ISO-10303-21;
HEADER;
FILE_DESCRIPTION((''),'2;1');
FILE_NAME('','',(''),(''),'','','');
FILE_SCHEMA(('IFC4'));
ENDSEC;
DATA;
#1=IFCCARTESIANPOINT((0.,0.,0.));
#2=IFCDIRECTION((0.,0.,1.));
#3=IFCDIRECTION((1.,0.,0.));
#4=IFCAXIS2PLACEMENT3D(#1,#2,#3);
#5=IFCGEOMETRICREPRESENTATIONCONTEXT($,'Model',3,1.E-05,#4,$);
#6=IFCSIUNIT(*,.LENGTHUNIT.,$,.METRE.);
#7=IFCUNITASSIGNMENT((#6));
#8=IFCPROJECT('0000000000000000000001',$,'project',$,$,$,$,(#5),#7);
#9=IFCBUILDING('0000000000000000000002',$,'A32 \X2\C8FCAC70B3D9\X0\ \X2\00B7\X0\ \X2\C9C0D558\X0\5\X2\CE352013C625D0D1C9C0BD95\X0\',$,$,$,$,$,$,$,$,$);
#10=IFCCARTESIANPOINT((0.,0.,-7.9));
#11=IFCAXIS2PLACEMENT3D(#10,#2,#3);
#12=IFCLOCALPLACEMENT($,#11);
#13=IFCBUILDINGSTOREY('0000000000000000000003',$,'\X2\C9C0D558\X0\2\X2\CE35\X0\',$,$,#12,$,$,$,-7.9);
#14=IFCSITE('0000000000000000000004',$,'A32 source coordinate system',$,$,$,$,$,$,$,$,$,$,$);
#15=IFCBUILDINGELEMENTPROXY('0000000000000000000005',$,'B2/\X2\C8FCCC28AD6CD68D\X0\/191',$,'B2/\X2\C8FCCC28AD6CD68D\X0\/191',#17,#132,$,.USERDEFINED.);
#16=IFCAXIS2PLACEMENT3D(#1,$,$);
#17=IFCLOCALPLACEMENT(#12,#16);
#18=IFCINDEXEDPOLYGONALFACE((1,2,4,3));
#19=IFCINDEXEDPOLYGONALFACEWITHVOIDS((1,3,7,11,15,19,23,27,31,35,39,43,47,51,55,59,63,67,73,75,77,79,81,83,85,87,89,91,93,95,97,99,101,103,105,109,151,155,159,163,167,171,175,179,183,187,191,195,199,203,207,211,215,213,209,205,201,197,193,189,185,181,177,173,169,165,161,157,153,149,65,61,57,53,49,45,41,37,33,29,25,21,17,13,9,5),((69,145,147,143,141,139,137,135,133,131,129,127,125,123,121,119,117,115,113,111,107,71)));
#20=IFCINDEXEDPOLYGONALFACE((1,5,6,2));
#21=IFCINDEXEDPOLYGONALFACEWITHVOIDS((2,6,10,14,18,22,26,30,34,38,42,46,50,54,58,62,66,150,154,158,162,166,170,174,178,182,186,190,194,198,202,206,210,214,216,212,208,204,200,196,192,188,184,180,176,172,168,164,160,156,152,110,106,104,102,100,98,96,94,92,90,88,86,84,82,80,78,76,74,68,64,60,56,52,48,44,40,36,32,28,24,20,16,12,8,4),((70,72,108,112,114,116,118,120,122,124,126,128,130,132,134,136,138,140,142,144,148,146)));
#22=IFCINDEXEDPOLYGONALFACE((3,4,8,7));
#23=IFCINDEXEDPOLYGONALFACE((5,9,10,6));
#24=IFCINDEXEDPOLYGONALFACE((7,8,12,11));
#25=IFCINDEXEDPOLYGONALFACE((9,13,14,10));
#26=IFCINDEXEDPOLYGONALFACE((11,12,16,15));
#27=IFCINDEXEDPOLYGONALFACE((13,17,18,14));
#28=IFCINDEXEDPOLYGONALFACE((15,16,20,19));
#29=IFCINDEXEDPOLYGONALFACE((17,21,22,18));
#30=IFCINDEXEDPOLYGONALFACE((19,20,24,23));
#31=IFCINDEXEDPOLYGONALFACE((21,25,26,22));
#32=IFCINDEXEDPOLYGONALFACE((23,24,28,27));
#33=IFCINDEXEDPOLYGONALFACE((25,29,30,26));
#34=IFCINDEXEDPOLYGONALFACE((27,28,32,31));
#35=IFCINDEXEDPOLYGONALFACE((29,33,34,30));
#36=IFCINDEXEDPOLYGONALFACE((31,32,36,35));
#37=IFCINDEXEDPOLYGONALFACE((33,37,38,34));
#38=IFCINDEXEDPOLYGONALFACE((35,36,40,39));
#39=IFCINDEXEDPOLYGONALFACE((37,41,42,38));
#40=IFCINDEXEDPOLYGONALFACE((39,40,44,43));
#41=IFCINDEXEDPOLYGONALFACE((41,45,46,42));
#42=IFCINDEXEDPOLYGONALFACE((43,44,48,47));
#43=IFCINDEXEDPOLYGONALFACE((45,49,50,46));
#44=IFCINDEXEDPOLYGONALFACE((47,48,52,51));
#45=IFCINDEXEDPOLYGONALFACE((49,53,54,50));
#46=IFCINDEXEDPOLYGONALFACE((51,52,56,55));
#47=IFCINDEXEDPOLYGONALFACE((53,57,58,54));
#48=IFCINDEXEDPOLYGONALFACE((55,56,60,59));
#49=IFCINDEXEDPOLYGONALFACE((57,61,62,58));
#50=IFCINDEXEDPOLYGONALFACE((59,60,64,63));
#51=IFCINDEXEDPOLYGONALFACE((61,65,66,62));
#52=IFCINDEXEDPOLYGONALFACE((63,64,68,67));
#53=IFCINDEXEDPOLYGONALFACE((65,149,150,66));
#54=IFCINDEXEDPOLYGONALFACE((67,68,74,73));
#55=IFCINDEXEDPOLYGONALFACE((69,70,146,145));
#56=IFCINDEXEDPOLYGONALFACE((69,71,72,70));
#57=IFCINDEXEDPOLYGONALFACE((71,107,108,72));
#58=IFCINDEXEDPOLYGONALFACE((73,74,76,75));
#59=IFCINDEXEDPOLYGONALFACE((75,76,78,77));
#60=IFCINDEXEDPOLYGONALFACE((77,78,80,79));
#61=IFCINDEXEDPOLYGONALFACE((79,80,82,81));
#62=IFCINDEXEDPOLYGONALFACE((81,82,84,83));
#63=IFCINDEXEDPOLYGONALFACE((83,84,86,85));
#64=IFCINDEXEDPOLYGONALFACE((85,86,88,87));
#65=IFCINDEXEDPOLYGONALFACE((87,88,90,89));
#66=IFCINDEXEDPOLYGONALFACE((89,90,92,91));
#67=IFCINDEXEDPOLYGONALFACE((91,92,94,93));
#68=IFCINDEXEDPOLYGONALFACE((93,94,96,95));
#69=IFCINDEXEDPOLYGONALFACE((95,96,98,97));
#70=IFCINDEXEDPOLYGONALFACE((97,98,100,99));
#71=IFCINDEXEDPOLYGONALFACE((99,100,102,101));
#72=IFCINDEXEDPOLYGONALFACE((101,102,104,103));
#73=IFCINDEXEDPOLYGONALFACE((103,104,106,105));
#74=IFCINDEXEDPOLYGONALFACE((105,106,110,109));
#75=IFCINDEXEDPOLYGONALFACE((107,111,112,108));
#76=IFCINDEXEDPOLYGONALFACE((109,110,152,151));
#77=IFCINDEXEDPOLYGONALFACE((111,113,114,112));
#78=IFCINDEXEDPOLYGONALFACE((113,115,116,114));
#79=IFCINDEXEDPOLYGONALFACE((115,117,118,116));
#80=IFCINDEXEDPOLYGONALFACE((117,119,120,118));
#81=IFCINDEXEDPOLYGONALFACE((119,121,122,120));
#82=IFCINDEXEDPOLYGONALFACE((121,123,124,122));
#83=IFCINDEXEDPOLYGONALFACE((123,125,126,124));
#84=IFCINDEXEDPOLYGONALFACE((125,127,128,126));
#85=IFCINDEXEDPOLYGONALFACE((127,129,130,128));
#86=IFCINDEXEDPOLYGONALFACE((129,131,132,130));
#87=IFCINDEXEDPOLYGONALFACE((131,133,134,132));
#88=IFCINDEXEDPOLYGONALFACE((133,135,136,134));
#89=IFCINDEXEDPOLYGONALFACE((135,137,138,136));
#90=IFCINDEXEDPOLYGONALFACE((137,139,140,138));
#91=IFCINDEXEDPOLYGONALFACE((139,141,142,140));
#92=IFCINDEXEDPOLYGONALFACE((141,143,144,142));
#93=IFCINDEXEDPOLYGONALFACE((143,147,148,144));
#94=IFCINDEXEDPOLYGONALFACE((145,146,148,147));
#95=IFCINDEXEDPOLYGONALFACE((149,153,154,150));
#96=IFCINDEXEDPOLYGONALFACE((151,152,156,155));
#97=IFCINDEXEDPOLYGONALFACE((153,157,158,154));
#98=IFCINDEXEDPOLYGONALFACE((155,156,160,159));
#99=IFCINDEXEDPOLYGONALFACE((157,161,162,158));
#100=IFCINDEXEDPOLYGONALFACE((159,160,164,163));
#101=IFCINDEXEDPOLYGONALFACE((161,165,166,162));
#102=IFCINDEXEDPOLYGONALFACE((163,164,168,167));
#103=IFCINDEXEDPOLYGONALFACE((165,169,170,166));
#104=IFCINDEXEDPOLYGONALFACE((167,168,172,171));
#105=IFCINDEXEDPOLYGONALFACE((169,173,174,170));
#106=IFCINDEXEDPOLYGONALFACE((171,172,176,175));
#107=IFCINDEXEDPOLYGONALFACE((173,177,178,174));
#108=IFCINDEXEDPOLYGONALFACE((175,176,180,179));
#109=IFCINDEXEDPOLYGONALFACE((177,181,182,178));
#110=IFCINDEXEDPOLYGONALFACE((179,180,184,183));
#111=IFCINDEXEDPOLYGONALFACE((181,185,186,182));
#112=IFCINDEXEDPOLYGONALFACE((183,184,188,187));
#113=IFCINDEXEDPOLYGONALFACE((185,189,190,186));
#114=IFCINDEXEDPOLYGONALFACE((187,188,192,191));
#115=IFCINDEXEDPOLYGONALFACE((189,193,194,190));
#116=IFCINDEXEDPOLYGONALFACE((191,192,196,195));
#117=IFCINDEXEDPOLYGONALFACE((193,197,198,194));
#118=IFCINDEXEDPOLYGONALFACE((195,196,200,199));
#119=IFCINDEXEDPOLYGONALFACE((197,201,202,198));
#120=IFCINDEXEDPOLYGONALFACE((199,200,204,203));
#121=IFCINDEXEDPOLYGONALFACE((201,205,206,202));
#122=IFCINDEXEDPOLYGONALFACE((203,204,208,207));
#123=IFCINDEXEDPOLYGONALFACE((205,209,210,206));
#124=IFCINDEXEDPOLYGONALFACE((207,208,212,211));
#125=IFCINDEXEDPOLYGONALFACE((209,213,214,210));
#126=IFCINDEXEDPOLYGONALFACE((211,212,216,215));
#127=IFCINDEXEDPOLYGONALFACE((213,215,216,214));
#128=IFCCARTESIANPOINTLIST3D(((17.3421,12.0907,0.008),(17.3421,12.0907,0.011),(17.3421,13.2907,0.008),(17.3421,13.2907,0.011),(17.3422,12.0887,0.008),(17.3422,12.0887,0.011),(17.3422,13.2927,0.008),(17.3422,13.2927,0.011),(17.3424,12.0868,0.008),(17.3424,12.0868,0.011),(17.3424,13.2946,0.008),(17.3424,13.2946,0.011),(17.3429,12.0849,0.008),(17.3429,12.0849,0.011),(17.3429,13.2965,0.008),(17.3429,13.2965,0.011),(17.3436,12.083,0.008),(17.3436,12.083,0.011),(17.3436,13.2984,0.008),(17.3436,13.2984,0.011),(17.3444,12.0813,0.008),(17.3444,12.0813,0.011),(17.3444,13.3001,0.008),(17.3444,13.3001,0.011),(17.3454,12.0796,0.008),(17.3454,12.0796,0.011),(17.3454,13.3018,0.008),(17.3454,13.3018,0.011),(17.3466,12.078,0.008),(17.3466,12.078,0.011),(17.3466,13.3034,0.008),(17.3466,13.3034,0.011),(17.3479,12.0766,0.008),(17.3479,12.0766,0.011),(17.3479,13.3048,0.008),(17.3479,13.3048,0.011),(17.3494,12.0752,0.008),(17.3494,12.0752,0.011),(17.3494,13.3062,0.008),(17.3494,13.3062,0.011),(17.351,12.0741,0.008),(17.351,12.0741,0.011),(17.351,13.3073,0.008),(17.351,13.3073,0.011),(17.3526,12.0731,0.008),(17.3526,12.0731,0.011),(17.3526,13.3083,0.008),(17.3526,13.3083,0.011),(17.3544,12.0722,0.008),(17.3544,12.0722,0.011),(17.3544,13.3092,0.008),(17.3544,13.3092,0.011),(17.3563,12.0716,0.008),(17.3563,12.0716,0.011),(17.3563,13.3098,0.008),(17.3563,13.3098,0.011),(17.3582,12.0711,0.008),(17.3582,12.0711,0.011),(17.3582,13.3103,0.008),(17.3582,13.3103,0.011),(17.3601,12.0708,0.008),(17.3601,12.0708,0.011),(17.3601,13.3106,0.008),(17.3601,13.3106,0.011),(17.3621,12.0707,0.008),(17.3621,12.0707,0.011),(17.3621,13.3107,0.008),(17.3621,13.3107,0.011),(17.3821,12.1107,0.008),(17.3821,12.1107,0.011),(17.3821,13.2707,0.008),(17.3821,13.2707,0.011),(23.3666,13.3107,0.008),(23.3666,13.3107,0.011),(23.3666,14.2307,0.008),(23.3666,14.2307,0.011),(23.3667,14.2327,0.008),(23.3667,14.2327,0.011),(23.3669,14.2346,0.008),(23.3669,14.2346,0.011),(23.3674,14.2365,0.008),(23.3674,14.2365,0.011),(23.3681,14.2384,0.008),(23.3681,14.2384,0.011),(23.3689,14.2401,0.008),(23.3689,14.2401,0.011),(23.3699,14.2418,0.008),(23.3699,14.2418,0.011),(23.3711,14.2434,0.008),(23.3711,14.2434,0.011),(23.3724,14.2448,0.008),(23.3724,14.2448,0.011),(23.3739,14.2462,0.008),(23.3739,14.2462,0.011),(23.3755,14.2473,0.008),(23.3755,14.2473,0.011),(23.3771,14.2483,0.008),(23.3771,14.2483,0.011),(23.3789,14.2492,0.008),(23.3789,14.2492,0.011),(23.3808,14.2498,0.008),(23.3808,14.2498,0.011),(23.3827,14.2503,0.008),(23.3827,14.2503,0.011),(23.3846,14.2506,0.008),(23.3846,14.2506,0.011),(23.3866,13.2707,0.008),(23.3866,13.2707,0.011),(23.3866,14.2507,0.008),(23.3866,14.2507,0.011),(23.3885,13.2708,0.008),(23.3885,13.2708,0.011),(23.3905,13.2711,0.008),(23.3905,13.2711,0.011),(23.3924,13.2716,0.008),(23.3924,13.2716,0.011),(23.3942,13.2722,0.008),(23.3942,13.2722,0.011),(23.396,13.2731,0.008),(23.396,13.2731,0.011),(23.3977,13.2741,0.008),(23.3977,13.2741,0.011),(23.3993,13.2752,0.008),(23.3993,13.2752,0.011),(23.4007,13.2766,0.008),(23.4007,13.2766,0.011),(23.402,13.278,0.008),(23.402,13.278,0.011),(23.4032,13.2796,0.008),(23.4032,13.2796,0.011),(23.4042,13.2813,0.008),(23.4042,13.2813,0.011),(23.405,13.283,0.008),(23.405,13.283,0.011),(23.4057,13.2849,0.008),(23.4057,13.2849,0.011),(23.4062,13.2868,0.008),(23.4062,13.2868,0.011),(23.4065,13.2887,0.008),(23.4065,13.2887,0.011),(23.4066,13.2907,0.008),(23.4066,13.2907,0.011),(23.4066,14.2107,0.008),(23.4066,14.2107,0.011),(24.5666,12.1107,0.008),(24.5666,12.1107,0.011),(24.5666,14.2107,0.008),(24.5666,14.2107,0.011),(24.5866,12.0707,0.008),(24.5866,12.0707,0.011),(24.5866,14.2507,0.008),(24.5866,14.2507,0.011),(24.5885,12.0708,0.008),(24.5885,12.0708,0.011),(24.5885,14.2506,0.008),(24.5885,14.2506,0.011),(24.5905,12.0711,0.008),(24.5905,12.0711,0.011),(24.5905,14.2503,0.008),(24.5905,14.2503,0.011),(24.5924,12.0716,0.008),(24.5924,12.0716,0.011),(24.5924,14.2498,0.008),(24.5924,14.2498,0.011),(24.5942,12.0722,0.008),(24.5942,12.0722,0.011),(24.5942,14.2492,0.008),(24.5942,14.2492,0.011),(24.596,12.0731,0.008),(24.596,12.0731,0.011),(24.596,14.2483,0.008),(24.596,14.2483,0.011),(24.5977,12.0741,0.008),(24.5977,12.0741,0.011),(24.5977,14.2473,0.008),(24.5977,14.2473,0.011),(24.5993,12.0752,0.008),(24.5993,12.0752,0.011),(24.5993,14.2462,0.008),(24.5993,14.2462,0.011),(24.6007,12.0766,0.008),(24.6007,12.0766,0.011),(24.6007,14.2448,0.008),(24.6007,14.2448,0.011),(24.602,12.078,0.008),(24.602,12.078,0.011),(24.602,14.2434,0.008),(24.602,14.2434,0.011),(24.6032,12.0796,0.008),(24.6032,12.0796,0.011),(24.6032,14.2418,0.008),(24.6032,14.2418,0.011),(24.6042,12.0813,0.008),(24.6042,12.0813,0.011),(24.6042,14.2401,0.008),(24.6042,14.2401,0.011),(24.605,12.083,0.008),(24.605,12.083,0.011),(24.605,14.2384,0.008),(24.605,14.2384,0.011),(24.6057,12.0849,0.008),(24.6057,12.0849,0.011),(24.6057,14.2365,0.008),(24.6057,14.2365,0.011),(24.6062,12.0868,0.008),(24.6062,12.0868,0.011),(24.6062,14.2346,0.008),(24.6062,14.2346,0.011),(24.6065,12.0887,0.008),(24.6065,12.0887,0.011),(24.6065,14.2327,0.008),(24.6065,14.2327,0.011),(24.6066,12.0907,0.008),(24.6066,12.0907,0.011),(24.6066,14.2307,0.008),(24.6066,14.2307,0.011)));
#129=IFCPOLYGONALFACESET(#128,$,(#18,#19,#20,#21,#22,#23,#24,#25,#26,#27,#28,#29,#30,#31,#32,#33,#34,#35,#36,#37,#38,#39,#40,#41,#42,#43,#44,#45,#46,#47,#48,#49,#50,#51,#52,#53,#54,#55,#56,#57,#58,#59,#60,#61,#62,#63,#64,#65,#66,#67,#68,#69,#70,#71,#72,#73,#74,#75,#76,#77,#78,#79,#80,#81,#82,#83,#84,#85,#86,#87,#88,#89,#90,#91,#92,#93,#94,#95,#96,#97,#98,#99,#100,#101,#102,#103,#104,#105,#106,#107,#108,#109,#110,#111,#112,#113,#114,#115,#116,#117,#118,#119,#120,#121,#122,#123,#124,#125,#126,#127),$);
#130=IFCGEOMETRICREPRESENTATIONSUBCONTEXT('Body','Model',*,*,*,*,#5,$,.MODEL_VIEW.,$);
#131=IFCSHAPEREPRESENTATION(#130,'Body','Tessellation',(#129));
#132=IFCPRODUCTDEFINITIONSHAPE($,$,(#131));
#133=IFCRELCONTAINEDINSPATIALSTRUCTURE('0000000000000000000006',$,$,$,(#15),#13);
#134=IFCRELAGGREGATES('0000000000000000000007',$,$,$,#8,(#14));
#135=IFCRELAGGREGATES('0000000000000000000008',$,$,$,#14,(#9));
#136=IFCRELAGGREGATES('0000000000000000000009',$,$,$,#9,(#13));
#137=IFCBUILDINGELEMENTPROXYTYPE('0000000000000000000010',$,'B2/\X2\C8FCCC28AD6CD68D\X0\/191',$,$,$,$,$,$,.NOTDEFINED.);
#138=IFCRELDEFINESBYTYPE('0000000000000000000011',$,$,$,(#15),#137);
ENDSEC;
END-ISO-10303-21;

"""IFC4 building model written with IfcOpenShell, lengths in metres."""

from ifc_helpers import new_model, si_unit, frame, origin, origin_with_axes, place, context, subcontext, project, spatial, polyline, outline, extrude, source, transform, mapped, type_object, type_shapes, element, save


model = new_model("IFC4")

# Units and contexts
model_context = context("Model", 3, precision=1e-05, world=origin_with_axes())
body_context = subcontext(model_context, "Body", "Model", "MODEL_VIEW")
ifc_project = project(units=[si_unit("LENGTHUNIT", "METRE")], contexts=[model_context])

# Site, building, storey
site = spatial("IfcSite", under=ifc_project, Name="A32 source coordinate system")
building = spatial("IfcBuilding", under=site, Name="A32 주거동 · 지하5층–옥탑지붕")
storey_placement = place(None, frame((0.0, 0.0, -7.9), z_axis=(0.0, 0.0, 1.0), x_axis=(1.0, 0.0, 0.0)))
storey = spatial("IfcBuildingStorey", under=building, at=storey_placement, Name="지하2층", Elevation=-7.9)

# Building element proxy
building_element_proxy_type_1 = type_object("IfcBuildingElementProxyType", Name="B2/주차구획/191", PredefinedType="NOTDEFINED")
shared_shape_1 = source(origin(), body_context, "Body", "SweptSolid", [
    extrude(outline(polyline([(24.5866, 14.2507), (24.5885, 14.2506), (24.5905, 14.2503), (24.5924, 14.2498), (24.5942, 14.2492), (24.596, 14.2483), (24.5977, 14.2473), (24.5993, 14.2462), (24.6007, 14.2448), (24.602, 14.2434), (24.6032, 14.2418), (24.6042, 14.2401), (24.605, 14.2384), (24.6057, 14.2365), (24.6062, 14.2346), (24.6065, 14.2327), (24.6066, 14.2307), (24.6066, 12.0907), (24.6065, 12.0887), (24.6062, 12.0868), (24.6057, 12.0849), (24.605, 12.083), (24.6042, 12.0813), (24.6032, 12.0796), (24.602, 12.078), (24.6007, 12.0766), (24.5993, 12.0752), (24.5977, 12.0741), (24.596, 12.0731), (24.5942, 12.0722), (24.5924, 12.0716), (24.5905, 12.0711), (24.5885, 12.0708), (24.5866, 12.0707), (17.3621, 12.0707), (17.3601, 12.0708), (17.3582, 12.0711), (17.3563, 12.0716), (17.3544, 12.0722), (17.3526, 12.0731), (17.351, 12.0741), (17.3494, 12.0752), (17.3479, 12.0766), (17.3466, 12.078), (17.3454, 12.0796), (17.3444, 12.0813), (17.3436, 12.083), (17.3429, 12.0849), (17.3424, 12.0868), (17.3422, 12.0887), (17.3421, 12.0907), (17.3421, 13.2907), (17.3422, 13.2927), (17.3424, 13.2946), (17.3429, 13.2965), (17.3436, 13.2984), (17.3444, 13.3001), (17.3454, 13.3018), (17.3466, 13.3034), (17.3479, 13.3048), (17.3494, 13.3062), (17.351, 13.3073), (17.3526, 13.3083), (17.3544, 13.3092), (17.3563, 13.3098), (17.3582, 13.3103), (17.3601, 13.3106), (17.3621, 13.3107), (23.3666, 13.3107), (23.3666, 14.2307), (23.3667, 14.2327), (23.3669, 14.2346), (23.3674, 14.2365), (23.3681, 14.2384), (23.3689, 14.2401), (23.3699, 14.2418), (23.3711, 14.2434), (23.3724, 14.2448), (23.3739, 14.2462), (23.3755, 14.2473), (23.3771, 14.2483), (23.3789, 14.2492), (23.3808, 14.2498), (23.3827, 14.2503), (23.3846, 14.2506), (23.3866, 14.2507), (24.5866, 14.2507)]), holes=[polyline([(24.5666, 14.2107), (23.4066, 14.2107), (23.4066, 13.2907), (23.4065, 13.2887), (23.4062, 13.2868), (23.4057, 13.2849), (23.405, 13.283), (23.4042, 13.2813), (23.4032, 13.2796), (23.402, 13.278), (23.4007, 13.2766), (23.3993, 13.2752), (23.3977, 13.2741), (23.396, 13.2731), (23.3942, 13.2722), (23.3924, 13.2716), (23.3905, 13.2711), (23.3885, 13.2708), (23.3866, 13.2707), (17.3821, 13.2707), (17.3821, 12.1107), (24.5666, 12.1107), (24.5666, 14.2107)])]), frame((0.0, 0.0, 0.008)), (0.0, 0.0, 1.0), 0.003),
])
type_shapes(building_element_proxy_type_1, [shared_shape_1])
proxy_1_placement = place(storey_placement, origin_with_axes())
element("IfcBuildingElementProxy", 1, at=proxy_1_placement, inside=storey, type_object=building_element_proxy_type_1, Name="B2/주차구획/191", ObjectType="B2/주차구획/191", PredefinedType="USERDEFINED", context=body_context, shape_type="MappedRepresentation", body=[
    mapped(shared_shape_1, transform((0.0, 0.0, 0.0), scale=1.0)),
])

save(model, "model.ifc")
